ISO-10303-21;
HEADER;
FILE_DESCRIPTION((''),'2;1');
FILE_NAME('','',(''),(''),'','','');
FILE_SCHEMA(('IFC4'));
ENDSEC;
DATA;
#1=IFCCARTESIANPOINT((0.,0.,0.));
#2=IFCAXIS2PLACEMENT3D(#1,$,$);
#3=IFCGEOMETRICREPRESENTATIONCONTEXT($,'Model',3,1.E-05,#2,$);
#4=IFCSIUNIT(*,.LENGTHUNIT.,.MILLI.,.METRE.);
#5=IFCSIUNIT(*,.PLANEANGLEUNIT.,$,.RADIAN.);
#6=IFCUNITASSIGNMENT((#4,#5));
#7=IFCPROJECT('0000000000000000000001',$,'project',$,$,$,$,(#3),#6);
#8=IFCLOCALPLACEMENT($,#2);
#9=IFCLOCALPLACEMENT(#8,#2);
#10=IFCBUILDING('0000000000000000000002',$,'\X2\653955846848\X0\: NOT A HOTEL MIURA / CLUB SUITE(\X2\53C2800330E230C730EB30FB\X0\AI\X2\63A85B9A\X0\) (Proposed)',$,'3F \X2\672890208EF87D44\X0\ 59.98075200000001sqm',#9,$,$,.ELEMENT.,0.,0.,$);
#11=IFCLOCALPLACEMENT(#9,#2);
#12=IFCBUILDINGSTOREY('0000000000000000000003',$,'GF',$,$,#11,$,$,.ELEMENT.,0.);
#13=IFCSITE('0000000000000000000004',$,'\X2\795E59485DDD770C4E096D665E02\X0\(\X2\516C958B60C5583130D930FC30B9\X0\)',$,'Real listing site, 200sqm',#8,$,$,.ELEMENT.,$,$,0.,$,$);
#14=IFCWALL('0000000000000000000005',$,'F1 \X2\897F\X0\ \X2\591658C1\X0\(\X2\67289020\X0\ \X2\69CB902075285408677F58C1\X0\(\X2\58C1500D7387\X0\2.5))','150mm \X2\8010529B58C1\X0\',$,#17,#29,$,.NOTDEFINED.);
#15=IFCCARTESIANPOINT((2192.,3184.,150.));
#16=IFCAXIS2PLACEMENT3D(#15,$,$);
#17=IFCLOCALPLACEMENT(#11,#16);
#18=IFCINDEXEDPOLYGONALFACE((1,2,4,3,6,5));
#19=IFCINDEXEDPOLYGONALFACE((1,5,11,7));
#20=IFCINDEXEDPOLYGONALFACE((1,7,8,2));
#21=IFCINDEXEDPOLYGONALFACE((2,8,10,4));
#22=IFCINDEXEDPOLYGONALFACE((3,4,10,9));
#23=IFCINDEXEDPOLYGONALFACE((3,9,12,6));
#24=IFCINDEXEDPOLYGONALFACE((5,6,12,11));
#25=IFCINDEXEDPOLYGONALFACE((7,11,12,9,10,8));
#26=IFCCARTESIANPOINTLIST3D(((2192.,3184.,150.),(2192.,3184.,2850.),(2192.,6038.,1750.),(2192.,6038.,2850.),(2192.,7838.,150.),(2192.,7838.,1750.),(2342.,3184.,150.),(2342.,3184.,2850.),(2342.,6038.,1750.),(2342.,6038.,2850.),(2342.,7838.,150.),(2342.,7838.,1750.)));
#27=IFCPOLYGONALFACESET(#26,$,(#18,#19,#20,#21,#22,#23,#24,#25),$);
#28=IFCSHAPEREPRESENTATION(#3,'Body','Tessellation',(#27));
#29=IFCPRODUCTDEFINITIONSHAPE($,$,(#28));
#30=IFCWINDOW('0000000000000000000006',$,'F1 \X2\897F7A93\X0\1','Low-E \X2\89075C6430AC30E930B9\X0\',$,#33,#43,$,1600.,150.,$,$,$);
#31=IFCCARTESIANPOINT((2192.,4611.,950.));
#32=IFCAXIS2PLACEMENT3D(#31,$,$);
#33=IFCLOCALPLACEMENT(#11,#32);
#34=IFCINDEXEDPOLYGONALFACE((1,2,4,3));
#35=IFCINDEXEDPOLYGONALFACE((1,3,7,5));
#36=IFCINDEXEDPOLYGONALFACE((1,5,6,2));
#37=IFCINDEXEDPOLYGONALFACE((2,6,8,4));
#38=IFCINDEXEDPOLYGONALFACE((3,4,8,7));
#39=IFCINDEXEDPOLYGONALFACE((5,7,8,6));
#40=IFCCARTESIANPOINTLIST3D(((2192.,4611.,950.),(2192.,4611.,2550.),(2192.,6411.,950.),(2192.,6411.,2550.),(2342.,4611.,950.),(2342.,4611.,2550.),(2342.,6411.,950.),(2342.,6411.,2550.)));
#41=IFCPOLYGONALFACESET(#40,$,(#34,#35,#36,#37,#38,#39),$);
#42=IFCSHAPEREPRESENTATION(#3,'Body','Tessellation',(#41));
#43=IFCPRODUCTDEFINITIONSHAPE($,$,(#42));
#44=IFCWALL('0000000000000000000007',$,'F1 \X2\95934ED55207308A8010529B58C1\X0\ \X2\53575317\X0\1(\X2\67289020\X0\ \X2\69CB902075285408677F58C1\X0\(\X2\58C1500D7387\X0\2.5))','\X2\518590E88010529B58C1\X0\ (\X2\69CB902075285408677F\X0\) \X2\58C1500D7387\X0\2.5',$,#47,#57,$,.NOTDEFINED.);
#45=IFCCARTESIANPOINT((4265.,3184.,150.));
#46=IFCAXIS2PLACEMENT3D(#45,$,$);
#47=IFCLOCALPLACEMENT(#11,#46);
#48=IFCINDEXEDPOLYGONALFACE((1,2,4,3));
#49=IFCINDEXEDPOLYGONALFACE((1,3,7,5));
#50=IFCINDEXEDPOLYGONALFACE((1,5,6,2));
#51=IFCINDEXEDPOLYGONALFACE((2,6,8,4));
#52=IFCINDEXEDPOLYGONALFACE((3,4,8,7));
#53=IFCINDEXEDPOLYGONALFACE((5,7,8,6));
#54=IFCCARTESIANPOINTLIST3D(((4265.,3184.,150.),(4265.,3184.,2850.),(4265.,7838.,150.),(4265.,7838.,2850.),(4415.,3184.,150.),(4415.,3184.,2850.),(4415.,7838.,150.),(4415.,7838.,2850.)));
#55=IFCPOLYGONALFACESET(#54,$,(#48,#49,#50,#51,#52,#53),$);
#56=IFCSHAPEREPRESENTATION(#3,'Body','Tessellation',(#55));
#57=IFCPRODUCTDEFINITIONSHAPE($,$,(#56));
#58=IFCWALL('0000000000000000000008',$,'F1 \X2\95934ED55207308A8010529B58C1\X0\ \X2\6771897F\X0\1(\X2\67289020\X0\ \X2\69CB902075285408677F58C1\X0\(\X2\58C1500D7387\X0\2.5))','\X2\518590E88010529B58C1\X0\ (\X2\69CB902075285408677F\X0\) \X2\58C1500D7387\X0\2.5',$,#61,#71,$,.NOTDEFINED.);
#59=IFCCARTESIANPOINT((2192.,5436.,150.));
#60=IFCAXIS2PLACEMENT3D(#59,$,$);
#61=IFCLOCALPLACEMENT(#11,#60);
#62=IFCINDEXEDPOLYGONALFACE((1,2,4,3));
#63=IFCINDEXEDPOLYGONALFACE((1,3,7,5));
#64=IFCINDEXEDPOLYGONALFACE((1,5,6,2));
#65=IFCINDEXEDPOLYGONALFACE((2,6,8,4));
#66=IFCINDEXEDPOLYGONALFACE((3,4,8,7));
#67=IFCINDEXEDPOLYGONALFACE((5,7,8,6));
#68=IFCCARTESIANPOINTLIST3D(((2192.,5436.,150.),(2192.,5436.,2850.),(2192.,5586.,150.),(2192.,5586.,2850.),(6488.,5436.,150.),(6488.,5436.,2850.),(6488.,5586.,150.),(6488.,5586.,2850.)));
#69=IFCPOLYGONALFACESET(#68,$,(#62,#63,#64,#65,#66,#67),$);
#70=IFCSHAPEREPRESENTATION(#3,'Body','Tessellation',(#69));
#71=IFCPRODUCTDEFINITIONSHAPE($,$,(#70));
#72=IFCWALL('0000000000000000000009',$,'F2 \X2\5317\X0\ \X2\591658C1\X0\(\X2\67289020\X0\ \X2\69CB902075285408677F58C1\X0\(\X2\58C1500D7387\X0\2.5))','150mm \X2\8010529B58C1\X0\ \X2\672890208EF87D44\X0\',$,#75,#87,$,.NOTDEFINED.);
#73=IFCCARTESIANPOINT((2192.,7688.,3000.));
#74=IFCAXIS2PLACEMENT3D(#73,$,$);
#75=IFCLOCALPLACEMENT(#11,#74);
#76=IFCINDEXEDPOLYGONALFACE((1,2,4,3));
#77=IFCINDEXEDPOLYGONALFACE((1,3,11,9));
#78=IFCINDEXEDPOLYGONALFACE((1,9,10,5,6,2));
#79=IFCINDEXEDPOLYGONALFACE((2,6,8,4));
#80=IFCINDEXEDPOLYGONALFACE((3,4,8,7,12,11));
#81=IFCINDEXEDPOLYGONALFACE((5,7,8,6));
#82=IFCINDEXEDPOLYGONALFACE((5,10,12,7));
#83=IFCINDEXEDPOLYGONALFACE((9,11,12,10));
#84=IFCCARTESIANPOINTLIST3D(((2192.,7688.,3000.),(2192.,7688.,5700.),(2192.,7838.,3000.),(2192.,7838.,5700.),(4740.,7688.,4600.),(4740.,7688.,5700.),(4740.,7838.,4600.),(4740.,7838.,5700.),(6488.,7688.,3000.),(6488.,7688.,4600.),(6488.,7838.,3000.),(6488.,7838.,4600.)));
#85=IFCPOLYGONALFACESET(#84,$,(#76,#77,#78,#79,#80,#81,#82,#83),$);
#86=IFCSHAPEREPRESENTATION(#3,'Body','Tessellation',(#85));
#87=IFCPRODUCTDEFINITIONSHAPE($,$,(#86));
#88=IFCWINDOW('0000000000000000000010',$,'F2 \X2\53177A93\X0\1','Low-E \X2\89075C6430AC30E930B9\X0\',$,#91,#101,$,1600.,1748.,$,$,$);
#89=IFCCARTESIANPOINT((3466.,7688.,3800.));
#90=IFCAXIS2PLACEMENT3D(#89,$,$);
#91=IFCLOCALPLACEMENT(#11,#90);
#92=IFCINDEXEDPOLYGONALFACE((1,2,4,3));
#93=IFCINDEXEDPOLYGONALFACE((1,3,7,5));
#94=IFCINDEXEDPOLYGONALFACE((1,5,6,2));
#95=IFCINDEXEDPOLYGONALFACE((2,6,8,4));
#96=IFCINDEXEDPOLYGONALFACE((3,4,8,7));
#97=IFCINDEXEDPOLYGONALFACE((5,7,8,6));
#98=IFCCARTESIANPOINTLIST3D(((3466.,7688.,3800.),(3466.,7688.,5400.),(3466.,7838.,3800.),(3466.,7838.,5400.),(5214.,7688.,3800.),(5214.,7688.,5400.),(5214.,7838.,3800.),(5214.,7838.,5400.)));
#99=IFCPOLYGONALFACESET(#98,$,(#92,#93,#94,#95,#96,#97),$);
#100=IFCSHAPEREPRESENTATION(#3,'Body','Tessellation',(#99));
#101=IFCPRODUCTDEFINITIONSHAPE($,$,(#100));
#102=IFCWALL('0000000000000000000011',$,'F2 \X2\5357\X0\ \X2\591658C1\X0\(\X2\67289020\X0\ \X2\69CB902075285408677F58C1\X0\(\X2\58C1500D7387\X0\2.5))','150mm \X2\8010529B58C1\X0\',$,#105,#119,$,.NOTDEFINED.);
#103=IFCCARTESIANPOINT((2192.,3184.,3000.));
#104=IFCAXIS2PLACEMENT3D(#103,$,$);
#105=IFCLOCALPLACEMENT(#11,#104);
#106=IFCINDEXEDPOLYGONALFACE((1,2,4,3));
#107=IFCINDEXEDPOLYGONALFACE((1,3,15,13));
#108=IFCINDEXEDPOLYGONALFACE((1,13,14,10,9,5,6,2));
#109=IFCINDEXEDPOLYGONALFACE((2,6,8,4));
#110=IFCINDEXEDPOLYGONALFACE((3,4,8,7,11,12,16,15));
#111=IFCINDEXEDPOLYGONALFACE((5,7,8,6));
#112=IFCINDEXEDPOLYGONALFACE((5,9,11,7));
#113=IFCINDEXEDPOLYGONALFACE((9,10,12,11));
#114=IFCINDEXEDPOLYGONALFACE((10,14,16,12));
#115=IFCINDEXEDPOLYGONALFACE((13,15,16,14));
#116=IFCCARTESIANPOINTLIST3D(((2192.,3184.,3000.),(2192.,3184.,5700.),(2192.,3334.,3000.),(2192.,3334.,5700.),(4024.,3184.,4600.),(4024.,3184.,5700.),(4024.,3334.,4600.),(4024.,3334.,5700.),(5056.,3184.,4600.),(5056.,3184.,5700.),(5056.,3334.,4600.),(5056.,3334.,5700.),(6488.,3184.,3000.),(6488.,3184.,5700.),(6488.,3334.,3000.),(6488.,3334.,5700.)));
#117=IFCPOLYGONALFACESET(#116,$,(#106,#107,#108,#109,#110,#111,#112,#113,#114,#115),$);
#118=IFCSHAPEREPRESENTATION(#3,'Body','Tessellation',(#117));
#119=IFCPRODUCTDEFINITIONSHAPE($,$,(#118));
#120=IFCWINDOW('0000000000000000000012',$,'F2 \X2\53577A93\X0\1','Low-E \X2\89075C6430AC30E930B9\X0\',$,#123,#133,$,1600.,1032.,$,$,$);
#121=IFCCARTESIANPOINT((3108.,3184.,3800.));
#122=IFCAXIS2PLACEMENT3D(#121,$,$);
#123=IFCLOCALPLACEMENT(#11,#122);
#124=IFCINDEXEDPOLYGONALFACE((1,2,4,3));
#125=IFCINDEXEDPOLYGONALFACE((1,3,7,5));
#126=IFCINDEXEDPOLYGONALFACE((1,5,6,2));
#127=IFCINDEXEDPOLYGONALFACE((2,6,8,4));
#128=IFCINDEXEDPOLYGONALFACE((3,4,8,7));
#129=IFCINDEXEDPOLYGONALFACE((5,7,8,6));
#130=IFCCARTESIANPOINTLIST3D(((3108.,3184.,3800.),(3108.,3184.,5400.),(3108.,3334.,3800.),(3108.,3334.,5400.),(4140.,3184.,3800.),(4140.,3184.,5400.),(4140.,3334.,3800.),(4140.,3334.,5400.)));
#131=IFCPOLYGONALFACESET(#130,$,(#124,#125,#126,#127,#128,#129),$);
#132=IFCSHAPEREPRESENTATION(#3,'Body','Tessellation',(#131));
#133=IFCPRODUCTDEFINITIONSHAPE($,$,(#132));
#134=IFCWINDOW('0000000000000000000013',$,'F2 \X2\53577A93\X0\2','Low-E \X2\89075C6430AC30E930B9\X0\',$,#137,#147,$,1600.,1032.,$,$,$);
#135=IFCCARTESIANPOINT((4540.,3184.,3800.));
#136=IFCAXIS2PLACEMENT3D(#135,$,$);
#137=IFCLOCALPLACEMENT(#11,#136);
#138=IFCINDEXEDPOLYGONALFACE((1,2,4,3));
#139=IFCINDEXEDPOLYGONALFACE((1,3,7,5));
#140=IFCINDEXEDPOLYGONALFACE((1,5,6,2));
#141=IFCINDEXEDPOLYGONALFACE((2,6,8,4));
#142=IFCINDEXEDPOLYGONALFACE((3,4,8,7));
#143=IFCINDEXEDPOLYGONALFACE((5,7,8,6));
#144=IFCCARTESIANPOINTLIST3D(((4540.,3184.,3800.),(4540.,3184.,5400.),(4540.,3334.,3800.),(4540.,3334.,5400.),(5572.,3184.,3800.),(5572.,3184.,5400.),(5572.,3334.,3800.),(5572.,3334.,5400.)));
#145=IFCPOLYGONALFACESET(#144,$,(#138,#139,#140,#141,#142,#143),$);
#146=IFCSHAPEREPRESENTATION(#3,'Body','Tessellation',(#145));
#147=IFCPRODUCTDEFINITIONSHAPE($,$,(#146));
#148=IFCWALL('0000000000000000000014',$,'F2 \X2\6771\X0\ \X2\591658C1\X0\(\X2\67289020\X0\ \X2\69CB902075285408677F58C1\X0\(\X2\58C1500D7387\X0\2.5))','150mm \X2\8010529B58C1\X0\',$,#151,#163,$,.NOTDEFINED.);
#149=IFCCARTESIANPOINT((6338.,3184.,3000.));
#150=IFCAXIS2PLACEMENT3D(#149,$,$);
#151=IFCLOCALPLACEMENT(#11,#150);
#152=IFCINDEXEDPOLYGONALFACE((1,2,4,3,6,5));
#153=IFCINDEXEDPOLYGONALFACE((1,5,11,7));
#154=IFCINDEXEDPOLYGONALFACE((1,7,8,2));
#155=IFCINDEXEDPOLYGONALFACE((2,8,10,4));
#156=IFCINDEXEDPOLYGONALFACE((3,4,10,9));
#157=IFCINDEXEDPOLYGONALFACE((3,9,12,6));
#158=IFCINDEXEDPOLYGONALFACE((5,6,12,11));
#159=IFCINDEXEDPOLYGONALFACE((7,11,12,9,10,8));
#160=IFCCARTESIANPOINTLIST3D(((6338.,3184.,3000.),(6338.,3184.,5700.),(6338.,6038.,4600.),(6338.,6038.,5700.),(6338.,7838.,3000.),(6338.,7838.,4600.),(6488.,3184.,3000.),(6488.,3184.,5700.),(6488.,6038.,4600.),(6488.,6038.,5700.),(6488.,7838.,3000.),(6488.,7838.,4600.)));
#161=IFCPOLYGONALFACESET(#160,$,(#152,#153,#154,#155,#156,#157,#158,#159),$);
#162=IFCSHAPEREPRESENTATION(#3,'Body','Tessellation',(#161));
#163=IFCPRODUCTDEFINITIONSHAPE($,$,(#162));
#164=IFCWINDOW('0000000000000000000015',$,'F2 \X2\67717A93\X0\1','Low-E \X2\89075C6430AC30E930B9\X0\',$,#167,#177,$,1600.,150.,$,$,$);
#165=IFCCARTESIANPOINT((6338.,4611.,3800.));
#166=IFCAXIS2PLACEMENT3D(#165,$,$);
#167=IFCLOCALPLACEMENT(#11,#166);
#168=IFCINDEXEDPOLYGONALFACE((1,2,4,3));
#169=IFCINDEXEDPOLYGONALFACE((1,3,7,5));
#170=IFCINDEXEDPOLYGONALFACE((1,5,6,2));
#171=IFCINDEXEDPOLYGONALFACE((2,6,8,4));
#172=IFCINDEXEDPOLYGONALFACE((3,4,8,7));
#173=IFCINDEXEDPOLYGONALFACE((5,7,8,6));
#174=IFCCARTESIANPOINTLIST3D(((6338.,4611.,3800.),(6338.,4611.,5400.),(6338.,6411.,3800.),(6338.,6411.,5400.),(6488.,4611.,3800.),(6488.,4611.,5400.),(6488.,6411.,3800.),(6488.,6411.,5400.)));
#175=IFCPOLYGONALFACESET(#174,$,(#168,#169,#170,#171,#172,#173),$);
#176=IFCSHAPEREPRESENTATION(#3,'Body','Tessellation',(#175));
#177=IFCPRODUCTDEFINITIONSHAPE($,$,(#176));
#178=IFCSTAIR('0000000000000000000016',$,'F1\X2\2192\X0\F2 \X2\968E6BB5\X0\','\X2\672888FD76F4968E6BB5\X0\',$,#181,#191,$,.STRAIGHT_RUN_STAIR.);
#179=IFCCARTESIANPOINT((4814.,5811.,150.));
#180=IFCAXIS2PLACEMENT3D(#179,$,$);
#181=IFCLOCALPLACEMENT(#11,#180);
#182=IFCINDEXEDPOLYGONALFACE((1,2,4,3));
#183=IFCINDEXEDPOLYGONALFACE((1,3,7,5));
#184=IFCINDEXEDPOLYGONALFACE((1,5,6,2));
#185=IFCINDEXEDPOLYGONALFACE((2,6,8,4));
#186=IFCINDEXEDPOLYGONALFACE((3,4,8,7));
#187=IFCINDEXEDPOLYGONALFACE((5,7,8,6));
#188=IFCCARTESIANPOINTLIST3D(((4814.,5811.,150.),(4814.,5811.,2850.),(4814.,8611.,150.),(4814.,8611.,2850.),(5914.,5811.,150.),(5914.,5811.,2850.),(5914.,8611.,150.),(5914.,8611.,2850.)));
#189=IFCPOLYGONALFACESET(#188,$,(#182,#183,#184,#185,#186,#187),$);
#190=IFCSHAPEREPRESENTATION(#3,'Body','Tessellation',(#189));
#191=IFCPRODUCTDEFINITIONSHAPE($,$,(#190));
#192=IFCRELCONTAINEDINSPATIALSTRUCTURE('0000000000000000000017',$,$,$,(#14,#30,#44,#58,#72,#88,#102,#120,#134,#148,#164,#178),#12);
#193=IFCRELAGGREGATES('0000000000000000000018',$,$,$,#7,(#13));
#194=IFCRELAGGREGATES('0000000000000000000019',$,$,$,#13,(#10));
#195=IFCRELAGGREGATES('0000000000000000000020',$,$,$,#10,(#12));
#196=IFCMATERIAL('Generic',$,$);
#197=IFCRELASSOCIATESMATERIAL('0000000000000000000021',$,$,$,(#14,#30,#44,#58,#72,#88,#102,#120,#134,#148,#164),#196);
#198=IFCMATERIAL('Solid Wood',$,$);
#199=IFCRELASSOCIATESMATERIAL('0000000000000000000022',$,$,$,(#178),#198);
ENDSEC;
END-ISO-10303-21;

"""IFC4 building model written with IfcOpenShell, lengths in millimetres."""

from ifc_helpers import new_model, si_unit, frame, frame_2d, origin, place, context, project, spatial, rectangle, extrude, material, element, fill, save


model = new_model("IFC4")

# Units and contexts
model_context = context("Model", 3, precision=1e-05, world=origin())
ifc_project = project(units=[si_unit("LENGTHUNIT", "METRE", prefix="MILLI"), si_unit("PLANEANGLEUNIT", "RADIAN")], contexts=[model_context])

# Site, building, storey
site_placement = place(None, origin())
site = spatial("IfcSite", under=ifc_project, at=site_placement, Name="神奈川県三浦市(公開情報ベース)", ObjectType="Real listing site, 200sqm", CompositionType="ELEMENT", RefElevation=0.0)
building_placement = place(site_placement, origin())
building = spatial("IfcBuilding", under=site, at=building_placement, Name="改善案: NOT A HOTEL MIURA / CLUB SUITE(参考モデル・AI推定) (Proposed)", ObjectType="3F 木造軸組 59.98075200000001sqm", CompositionType="ELEMENT", ElevationOfRefHeight=0.0, ElevationOfTerrain=0.0)
storey_placement = place(building_placement, origin())
storey = spatial("IfcBuildingStorey", under=building, at=storey_placement, Name="GF", CompositionType="ELEMENT", Elevation=0.0)

# Shared definitions
ifc_material_1 = material(Name="Generic")

# Shared definitions
ifc_material_2 = material(Name="Solid Wood")

# Wall, opening, window
wall_1_placement = place(storey_placement, frame((2192.0, 3184.0, 150.0)))
wall_1 = element("IfcWall", 1, at=wall_1_placement, inside=storey, material=ifc_material_1, Name="F1 西 外壁(木造 構造用合板壁(壁倍率2.5))", Description="150mm 耐力壁", PredefinedType="NOTDEFINED", context=model_context, shape_type="SweptSolid", body=[
    extrude(rectangle(XDim=150.0, YDim=4654.0, at=frame_2d((75.0, 2327.0))), frame((2192.0, 3184.0, 150.0)), (0.0, 0.0, 1.0), 2700.0),
])
opening_1_placement = place(storey_placement, frame((2192.0, 4611.0, 950.0)))
opening_1 = element("IfcOpeningElement", 2, at=opening_1_placement, cuts=wall_1, PredefinedType="NOTDEFINED", context=model_context, shape_type="SweptSolid", body=[
    extrude(rectangle(XDim=150.0, YDim=1800.0, at=frame_2d((75.0, 900.0))), frame((2192.0, 4611.0, 950.0)), (0.0, 0.0, 1.0), 1600.0),
])
window_1_placement = place(storey_placement, frame((2192.0, 4611.0, 950.0)))
window_1 = element("IfcWindow", 3, at=window_1_placement, inside=storey, material=ifc_material_1, Name="F1 西窓1", Description="Low-E 複層ガラス", OverallHeight=1600.0, OverallWidth=150.0, context=model_context, shape_type="SweptSolid", body=[
    extrude(rectangle(XDim=150.0, YDim=1800.0, at=frame_2d((75.0, 900.0))), frame((2192.0, 4611.0, 950.0)), (0.0, 0.0, 1.0), 1600.0),
])
fill(opening_1, window_1)

# Walls
wall_2_placement = place(storey_placement, frame((4265.0, 3184.0, 150.0)))
element("IfcWall", 4, at=wall_2_placement, inside=storey, material=ifc_material_1, Name="F1 間仕切り耐力壁 南北1(木造 構造用合板壁(壁倍率2.5))", Description="内部耐力壁 (構造用合板) 壁倍率2.5", PredefinedType="NOTDEFINED", context=model_context, shape_type="SweptSolid", body=[
    extrude(rectangle(XDim=150.0, YDim=4654.0, at=frame_2d((75.0, 2327.0))), frame((4265.0, 3184.0, 150.0)), (0.0, 0.0, 1.0), 2700.0),
])
wall_3_placement = place(storey_placement, frame((2192.0, 5436.0, 150.0)))
element("IfcWall", 5, at=wall_3_placement, inside=storey, material=ifc_material_1, Name="F1 間仕切り耐力壁 東西1(木造 構造用合板壁(壁倍率2.5))", Description="内部耐力壁 (構造用合板) 壁倍率2.5", PredefinedType="NOTDEFINED", context=model_context, shape_type="SweptSolid", body=[
    extrude(rectangle(XDim=4296.0, YDim=150.0, at=frame_2d((2148.0, 75.0))), frame((2192.0, 5436.0, 150.0)), (0.0, 0.0, 1.0), 2700.0),
])

# Wall, opening, window
wall_4_placement = place(storey_placement, frame((2192.0, 7688.0, 3000.0)))
wall_4 = element("IfcWall", 6, at=wall_4_placement, inside=storey, material=ifc_material_1, Name="F2 北 外壁(木造 構造用合板壁(壁倍率2.5))", Description="150mm 耐力壁 木造軸組", PredefinedType="NOTDEFINED", context=model_context, shape_type="SweptSolid", body=[
    extrude(rectangle(XDim=4296.0, YDim=150.0, at=frame_2d((2148.0, 75.0))), frame((2192.0, 7688.0, 3000.0)), (0.0, 0.0, 1.0), 2700.0),
])
opening_2_placement = place(storey_placement, frame((3466.0, 7688.0, 3800.0)))
opening_2 = element("IfcOpeningElement", 7, at=opening_2_placement, cuts=wall_4, PredefinedType="NOTDEFINED", context=model_context, shape_type="SweptSolid", body=[
    extrude(rectangle(XDim=1748.0, YDim=150.0, at=frame_2d((874.0, 75.0))), frame((3466.0, 7688.0, 3800.0)), (0.0, 0.0, 1.0), 1600.0),
])
window_2_placement = place(storey_placement, frame((3466.0, 7688.0, 3800.0)))
window_2 = element("IfcWindow", 8, at=window_2_placement, inside=storey, material=ifc_material_1, Name="F2 北窓1", Description="Low-E 複層ガラス", OverallHeight=1600.0, OverallWidth=1748.0, context=model_context, shape_type="SweptSolid", body=[
    extrude(rectangle(XDim=1748.0, YDim=150.0, at=frame_2d((874.0, 75.0))), frame((3466.0, 7688.0, 3800.0)), (0.0, 0.0, 1.0), 1600.0),
])
fill(opening_2, window_2)

# Wall, openings, windows
wall_5_placement = place(storey_placement, frame((2192.0, 3184.0, 3000.0)))
wall_5 = element("IfcWall", 9, at=wall_5_placement, inside=storey, material=ifc_material_1, Name="F2 南 外壁(木造 構造用合板壁(壁倍率2.5))", Description="150mm 耐力壁", PredefinedType="NOTDEFINED", context=model_context, shape_type="SweptSolid", body=[
    extrude(rectangle(XDim=4296.0, YDim=150.0, at=frame_2d((2148.0, 75.0))), frame((2192.0, 3184.0, 3000.0)), (0.0, 0.0, 1.0), 2700.0),
])
opening_3_placement = place(storey_placement, frame((3108.0, 3184.0, 3800.0)))
opening_3 = element("IfcOpeningElement", 10, at=opening_3_placement, cuts=wall_5, PredefinedType="NOTDEFINED", context=model_context, shape_type="SweptSolid", body=[
    extrude(rectangle(XDim=1032.0, YDim=150.0, at=frame_2d((516.0, 75.0))), frame((3108.0, 3184.0, 3800.0)), (0.0, 0.0, 1.0), 1600.0),
])
opening_4_placement = place(storey_placement, frame((4540.0, 3184.0, 3800.0)))
opening_4 = element("IfcOpeningElement", 11, at=opening_4_placement, cuts=wall_5, PredefinedType="NOTDEFINED", context=model_context, shape_type="SweptSolid", body=[
    extrude(rectangle(XDim=1032.0, YDim=150.0, at=frame_2d((516.0, 75.0))), frame((4540.0, 3184.0, 3800.0)), (0.0, 0.0, 1.0), 1600.0),
])
window_3_placement = place(storey_placement, frame((3108.0, 3184.0, 3800.0)))
window_3 = element("IfcWindow", 12, at=window_3_placement, inside=storey, material=ifc_material_1, Name="F2 南窓1", Description="Low-E 複層ガラス", OverallHeight=1600.0, OverallWidth=1032.0, context=model_context, shape_type="SweptSolid", body=[
    extrude(rectangle(XDim=1032.0, YDim=150.0, at=frame_2d((516.0, 75.0))), frame((3108.0, 3184.0, 3800.0)), (0.0, 0.0, 1.0), 1600.0),
])
fill(opening_3, window_3)
window_4_placement = place(storey_placement, frame((4540.0, 3184.0, 3800.0)))
window_4 = element("IfcWindow", 13, at=window_4_placement, inside=storey, material=ifc_material_1, Name="F2 南窓2", Description="Low-E 複層ガラス", OverallHeight=1600.0, OverallWidth=1032.0, context=model_context, shape_type="SweptSolid", body=[
    extrude(rectangle(XDim=1032.0, YDim=150.0, at=frame_2d((516.0, 75.0))), frame((4540.0, 3184.0, 3800.0)), (0.0, 0.0, 1.0), 1600.0),
])
fill(opening_4, window_4)

# Wall, opening, window
wall_6_placement = place(storey_placement, frame((6338.0, 3184.0, 3000.0)))
wall_6 = element("IfcWall", 14, at=wall_6_placement, inside=storey, material=ifc_material_1, Name="F2 東 外壁(木造 構造用合板壁(壁倍率2.5))", Description="150mm 耐力壁", PredefinedType="NOTDEFINED", context=model_context, shape_type="SweptSolid", body=[
    extrude(rectangle(XDim=150.0, YDim=4654.0, at=frame_2d((75.0, 2327.0))), frame((6338.0, 3184.0, 3000.0)), (0.0, 0.0, 1.0), 2700.0),
])
opening_5_placement = place(storey_placement, frame((6338.0, 4611.0, 3800.0)))
opening_5 = element("IfcOpeningElement", 15, at=opening_5_placement, cuts=wall_6, PredefinedType="NOTDEFINED", context=model_context, shape_type="SweptSolid", body=[
    extrude(rectangle(XDim=150.0, YDim=1800.0, at=frame_2d((75.0, 900.0))), frame((6338.0, 4611.0, 3800.0)), (0.0, 0.0, 1.0), 1600.0),
])
window_5_placement = place(storey_placement, frame((6338.0, 4611.0, 3800.0)))
window_5 = element("IfcWindow", 16, at=window_5_placement, inside=storey, material=ifc_material_1, Name="F2 東窓1", Description="Low-E 複層ガラス", OverallHeight=1600.0, OverallWidth=150.0, context=model_context, shape_type="SweptSolid", body=[
    extrude(rectangle(XDim=150.0, YDim=1800.0, at=frame_2d((75.0, 900.0))), frame((6338.0, 4611.0, 3800.0)), (0.0, 0.0, 1.0), 1600.0),
])
fill(opening_5, window_5)

# Stair
stair_placement = place(storey_placement, frame((4814.0, 5811.0, 150.0)))
element("IfcStair", 17, at=stair_placement, inside=storey, material=ifc_material_2, Name="F1→F2 階段", Description="木製直階段", PredefinedType="STRAIGHT_RUN_STAIR", context=model_context, shape_type="SweptSolid", body=[
    extrude(rectangle(XDim=1100.0, YDim=2800.0, at=frame_2d((550.0, 1400.0))), frame((4814.0, 5811.0, 150.0)), (0.0, 0.0, 1.0), 2700.0),
])

save(model, "model.ifc")
